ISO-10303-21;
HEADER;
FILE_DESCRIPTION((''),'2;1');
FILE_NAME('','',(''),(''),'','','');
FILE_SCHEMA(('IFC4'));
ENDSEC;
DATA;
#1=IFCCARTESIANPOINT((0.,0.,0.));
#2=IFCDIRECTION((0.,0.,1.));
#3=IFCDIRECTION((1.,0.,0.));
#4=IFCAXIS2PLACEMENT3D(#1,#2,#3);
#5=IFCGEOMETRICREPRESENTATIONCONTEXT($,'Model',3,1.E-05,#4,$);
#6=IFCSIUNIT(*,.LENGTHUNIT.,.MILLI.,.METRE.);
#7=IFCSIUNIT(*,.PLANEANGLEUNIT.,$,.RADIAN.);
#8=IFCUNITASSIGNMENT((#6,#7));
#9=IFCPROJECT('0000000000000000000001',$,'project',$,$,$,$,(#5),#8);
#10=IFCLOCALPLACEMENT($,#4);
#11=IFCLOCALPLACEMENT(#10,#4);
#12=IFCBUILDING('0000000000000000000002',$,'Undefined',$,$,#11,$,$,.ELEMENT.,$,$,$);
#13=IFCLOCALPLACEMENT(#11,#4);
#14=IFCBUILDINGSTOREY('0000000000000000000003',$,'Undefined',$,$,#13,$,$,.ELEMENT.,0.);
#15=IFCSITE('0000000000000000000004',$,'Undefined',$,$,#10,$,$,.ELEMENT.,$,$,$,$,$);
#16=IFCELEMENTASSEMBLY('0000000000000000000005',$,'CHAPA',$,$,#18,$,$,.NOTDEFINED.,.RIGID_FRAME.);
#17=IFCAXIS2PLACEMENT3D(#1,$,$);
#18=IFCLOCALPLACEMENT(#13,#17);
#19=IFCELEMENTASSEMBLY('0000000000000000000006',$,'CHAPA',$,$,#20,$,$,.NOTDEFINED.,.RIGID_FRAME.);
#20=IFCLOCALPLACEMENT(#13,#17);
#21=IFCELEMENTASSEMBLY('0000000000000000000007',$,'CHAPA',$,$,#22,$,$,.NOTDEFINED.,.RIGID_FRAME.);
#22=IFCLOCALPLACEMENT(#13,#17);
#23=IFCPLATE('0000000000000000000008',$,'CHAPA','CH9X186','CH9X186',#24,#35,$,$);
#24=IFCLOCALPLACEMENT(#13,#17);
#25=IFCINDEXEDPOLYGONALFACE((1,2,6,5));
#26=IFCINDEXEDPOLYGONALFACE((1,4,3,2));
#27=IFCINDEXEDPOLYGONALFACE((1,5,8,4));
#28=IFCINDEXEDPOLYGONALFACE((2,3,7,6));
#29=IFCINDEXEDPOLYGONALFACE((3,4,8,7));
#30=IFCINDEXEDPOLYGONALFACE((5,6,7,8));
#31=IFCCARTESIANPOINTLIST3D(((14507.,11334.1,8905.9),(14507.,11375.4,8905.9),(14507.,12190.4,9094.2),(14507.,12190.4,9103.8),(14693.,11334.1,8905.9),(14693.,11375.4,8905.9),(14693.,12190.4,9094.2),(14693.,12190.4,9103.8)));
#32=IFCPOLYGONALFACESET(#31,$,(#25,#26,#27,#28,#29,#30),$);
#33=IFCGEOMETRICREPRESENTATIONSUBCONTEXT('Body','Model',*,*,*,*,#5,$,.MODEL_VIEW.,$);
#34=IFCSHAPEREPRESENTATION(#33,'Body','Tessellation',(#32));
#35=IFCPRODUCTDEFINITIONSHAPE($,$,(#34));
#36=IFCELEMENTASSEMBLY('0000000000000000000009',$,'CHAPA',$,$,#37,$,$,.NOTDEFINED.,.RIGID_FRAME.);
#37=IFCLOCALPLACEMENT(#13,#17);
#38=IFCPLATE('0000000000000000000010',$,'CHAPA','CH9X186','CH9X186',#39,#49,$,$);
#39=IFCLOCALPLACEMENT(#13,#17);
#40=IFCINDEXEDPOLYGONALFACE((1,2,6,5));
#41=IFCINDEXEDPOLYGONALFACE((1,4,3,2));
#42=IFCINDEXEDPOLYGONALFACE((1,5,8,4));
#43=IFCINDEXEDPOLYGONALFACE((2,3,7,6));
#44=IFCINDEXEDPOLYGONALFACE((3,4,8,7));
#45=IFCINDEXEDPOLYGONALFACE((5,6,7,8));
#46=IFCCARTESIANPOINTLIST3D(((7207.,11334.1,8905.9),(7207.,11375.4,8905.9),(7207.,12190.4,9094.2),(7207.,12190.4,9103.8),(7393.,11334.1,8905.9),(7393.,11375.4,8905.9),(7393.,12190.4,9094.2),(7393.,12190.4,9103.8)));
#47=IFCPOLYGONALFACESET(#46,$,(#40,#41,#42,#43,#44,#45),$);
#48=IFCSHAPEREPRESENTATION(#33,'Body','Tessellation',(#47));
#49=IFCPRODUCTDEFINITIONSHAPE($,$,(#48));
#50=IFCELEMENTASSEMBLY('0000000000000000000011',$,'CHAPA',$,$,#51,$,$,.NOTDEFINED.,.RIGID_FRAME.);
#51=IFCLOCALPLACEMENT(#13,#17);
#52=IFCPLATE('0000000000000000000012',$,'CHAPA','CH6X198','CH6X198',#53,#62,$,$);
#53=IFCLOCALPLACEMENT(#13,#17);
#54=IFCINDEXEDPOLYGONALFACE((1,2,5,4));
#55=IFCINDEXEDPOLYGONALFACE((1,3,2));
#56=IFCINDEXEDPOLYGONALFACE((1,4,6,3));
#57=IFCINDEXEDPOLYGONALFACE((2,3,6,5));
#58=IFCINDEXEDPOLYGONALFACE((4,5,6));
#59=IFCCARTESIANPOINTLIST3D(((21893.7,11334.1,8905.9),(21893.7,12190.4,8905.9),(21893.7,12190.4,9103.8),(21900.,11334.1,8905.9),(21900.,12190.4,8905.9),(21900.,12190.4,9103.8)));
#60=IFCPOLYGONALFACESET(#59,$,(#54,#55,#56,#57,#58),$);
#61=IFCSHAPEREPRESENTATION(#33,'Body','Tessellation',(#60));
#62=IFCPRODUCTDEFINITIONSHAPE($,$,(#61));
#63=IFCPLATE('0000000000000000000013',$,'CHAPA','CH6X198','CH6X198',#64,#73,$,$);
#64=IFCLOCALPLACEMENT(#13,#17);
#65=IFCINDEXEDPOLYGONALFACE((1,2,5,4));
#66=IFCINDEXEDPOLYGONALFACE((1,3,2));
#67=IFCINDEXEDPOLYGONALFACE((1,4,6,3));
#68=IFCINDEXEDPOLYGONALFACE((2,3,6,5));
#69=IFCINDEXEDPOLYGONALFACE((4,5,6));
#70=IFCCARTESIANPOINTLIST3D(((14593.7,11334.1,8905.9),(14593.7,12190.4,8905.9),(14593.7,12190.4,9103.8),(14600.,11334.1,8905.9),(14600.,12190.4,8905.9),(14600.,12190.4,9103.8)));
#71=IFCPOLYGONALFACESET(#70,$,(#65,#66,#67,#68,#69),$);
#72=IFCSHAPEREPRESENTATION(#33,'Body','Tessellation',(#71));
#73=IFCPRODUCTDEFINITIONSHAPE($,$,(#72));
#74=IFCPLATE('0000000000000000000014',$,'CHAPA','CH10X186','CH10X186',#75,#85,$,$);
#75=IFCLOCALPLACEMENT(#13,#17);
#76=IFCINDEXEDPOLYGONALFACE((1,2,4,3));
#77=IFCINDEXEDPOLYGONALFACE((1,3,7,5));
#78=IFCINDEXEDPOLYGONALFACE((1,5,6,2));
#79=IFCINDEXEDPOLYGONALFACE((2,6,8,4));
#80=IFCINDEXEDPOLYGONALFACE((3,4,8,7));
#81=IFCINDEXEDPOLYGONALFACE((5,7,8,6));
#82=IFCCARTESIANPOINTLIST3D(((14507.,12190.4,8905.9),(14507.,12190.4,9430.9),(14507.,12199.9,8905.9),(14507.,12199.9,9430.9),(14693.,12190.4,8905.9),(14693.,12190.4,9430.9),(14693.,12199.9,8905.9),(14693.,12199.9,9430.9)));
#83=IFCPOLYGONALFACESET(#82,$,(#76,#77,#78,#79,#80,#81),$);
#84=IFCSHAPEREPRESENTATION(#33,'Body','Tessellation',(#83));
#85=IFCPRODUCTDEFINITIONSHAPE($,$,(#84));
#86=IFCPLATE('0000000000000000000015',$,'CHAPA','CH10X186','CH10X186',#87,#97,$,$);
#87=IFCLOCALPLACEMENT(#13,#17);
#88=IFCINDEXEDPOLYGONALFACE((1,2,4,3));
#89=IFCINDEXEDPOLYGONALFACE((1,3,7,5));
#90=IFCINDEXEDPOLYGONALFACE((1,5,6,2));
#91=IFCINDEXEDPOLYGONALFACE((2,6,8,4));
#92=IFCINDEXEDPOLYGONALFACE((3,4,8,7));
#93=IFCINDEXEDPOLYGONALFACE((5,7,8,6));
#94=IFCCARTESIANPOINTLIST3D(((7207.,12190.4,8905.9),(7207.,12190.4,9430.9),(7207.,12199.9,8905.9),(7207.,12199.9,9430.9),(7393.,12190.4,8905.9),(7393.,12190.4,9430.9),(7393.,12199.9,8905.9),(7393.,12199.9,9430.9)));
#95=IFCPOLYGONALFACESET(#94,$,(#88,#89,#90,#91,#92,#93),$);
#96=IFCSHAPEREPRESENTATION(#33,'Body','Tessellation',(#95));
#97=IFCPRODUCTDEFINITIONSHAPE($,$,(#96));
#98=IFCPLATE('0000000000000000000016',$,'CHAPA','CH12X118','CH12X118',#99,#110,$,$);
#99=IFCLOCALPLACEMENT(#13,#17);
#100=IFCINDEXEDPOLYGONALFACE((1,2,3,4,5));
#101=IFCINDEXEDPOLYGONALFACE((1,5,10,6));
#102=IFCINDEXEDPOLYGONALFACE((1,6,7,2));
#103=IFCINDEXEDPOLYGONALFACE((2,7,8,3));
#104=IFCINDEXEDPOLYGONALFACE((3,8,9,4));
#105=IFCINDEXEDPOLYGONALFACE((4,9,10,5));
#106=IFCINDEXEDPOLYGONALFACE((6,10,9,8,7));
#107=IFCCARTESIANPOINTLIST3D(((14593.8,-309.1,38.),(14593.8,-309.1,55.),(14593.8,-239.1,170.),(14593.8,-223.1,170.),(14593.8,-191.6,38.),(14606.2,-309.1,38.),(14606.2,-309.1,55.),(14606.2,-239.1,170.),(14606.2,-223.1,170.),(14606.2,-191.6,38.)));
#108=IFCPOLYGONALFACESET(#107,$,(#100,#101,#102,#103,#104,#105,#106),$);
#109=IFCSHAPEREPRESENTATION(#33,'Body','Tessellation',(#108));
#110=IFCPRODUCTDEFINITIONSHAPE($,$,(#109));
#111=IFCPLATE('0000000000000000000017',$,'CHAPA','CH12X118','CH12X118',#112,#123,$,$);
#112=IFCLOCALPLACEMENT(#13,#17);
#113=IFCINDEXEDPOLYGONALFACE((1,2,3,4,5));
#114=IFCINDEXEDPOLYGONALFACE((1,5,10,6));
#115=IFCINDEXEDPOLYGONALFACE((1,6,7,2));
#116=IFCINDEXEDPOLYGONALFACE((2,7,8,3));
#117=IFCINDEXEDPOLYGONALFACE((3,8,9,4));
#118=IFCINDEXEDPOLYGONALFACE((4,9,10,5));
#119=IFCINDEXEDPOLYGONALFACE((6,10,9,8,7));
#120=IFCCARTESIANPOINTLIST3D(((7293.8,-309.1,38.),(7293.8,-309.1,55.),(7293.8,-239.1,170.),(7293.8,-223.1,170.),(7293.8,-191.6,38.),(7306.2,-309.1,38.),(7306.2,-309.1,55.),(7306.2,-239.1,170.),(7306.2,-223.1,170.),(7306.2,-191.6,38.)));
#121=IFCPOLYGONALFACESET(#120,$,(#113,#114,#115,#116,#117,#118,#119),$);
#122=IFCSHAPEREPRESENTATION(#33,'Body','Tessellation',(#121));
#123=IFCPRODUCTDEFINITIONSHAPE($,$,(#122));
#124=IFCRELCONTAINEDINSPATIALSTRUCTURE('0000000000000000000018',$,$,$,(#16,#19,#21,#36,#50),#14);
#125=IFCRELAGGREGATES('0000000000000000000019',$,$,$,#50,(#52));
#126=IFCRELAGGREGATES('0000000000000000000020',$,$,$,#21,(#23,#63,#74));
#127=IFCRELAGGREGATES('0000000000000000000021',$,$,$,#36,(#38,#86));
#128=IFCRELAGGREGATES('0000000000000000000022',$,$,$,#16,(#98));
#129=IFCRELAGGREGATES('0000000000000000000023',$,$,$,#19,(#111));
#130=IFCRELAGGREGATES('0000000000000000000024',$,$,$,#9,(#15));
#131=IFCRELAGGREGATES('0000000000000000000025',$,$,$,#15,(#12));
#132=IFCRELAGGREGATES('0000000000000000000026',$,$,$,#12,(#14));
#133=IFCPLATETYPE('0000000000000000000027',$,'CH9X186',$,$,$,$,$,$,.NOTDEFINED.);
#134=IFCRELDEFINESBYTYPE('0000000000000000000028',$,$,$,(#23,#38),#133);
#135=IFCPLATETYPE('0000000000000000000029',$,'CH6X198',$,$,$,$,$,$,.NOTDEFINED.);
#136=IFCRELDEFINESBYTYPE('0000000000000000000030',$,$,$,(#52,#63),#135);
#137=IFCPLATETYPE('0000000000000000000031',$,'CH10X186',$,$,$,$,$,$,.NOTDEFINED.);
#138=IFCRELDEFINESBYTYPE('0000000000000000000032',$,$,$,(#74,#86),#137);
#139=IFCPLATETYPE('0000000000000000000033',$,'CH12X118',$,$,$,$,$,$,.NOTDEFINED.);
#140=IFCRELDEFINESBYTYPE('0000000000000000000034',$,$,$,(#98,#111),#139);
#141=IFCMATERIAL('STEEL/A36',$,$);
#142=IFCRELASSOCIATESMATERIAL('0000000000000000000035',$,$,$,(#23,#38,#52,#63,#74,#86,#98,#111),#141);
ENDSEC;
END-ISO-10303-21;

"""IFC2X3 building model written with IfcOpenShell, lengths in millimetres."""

from ifc_helpers import new_model, si_unit, frame, origin_with_axes, place, context, subcontext, project, spatial, polyline, outline, extrude, clip, halfspace, material, type_object, element, aggregate, save


model = new_model("IFC2X3")

# Units and contexts
model_context = context("Model", 3, precision=1e-05, world=origin_with_axes())
body_context = subcontext(model_context, "Body", "Model", "MODEL_VIEW")
ifc_project = project(units=[si_unit("LENGTHUNIT", "METRE", prefix="MILLI"), si_unit("PLANEANGLEUNIT", "RADIAN")], contexts=[model_context])

# Site, building, storey
site_placement = place(None, origin_with_axes())
site = spatial("IfcSite", under=ifc_project, at=site_placement, Name="Undefined", CompositionType="ELEMENT")
building_placement = place(site_placement, origin_with_axes())
building = spatial("IfcBuilding", under=site, at=building_placement, Name="Undefined", CompositionType="ELEMENT")
storey_placement = place(building_placement, origin_with_axes())
storey = spatial("IfcBuildingStorey", under=building, at=storey_placement, Name="Undefined", CompositionType="ELEMENT", Elevation=0.0)

# Element assemblies
assembly_1_placement = place(storey_placement, origin_with_axes())
assembly_1 = element("IfcElementAssembly", 1, at=assembly_1_placement, inside=storey, Name="CHAPA", AssemblyPlace="NOTDEFINED", PredefinedType="RIGID_FRAME")
assembly_2_placement = place(storey_placement, origin_with_axes())
assembly_2 = element("IfcElementAssembly", 2, at=assembly_2_placement, inside=storey, Name="CHAPA", AssemblyPlace="NOTDEFINED", PredefinedType="RIGID_FRAME")

# Shared definitions
ifc_material_1 = material(Name="STEEL/A36")

# Element assemblies, plates
assembly_3_placement = place(storey_placement, origin_with_axes())
assembly_3 = element("IfcElementAssembly", 3, at=assembly_3_placement, inside=storey, Name="CHAPA", AssemblyPlace="NOTDEFINED", PredefinedType="RIGID_FRAME")
plate_type_1 = type_object("IfcPlateType", Name="CH9X186", PredefinedType="NOTDEFINED")
plate_1_placement = place(assembly_3_placement, frame((14693.0, 12191.4, 9099.3), z_axis=(0.0, -0.225125, 0.97433), x_axis=(-1.0, 0.0, 0.0)))
plate_1 = element("IfcPlate", 4, at=plate_1_placement, type_object=plate_type_1, material=ifc_material_1, Name="CHAPA", Description="CH9X186", ObjectType="CH9X186", context=body_context, shape_type="Clipping", body=[
    clip(clip(extrude(outline(polyline([(0.0, 0.0), (186.0, 0.0), (186.0, 878.9), (0.0, 878.9), (0.0, 0.0)])), frame((0.0, 0.0, -4.7), z_axis=(0.0, 0.0, 1.0), x_axis=(1.0, 0.0, 0.0)), (0.0, 0.0, 1.0), 9.3), halfspace(frame((186.0, -500.0, -314.0), z_axis=(0.0, 0.225128, -0.974329), x_axis=(0.0, 0.974329, 0.225128)), False)), halfspace(frame((0.0, 2.1, -4.6), z_axis=(0.0, -0.97433, -0.225125), x_axis=(0.0, -0.225125, 0.97433)), False)),
])
assembly_4_placement = place(storey_placement, origin_with_axes())
assembly_4 = element("IfcElementAssembly", 5, at=assembly_4_placement, inside=storey, Name="CHAPA", AssemblyPlace="NOTDEFINED", PredefinedType="RIGID_FRAME")
plate_2_placement = place(assembly_4_placement, frame((7393.0, 12191.4, 9099.3), z_axis=(0.0, -0.225125, 0.97433), x_axis=(-1.0, 0.0, 0.0)))
plate_2 = element("IfcPlate", 6, at=plate_2_placement, type_object=plate_type_1, material=ifc_material_1, Name="CHAPA", Description="CH9X186", ObjectType="CH9X186", context=body_context, shape_type="Clipping", body=[
    clip(clip(extrude(outline(polyline([(0.0, 0.0), (186.0, 0.0), (186.0, 878.9), (0.0, 878.9), (0.0, 0.0)])), frame((0.0, 0.0, -4.7), z_axis=(0.0, 0.0, 1.0), x_axis=(1.0, 0.0, 0.0)), (0.0, 0.0, 1.0), 9.3), halfspace(frame((186.0, -500.0, -314.0), z_axis=(0.0, 0.225128, -0.974329), x_axis=(0.0, 0.974329, 0.225128)), False)), halfspace(frame((0.0, 2.1, -4.6), z_axis=(0.0, -0.97433, -0.225125), x_axis=(0.0, -0.225125, 0.97433)), False)),
])
assembly_5_placement = place(storey_placement, origin_with_axes())
assembly_5 = element("IfcElementAssembly", 7, at=assembly_5_placement, inside=storey, Name="CHAPA", AssemblyPlace="NOTDEFINED", PredefinedType="RIGID_FRAME")
plate_type_2 = type_object("IfcPlateType", Name="CH6X198", PredefinedType="NOTDEFINED")
plate_3_placement = place(assembly_5_placement, frame((21896.8, 11334.1, 8905.9), z_axis=(1.0, 0.0, 0.0), x_axis=(0.0, 1.0, 0.0)))
plate_3 = element("IfcPlate", 8, at=plate_3_placement, type_object=plate_type_2, material=ifc_material_1, Name="CHAPA", Description="CH6X198", ObjectType="CH6X198", context=body_context, shape_type="SweptSolid", body=[
    extrude(outline(polyline([(0.0, 0.0), (856.3, 0.0), (856.3, 197.9), (0.0, 0.0)])), frame((0.0, 0.0, -3.1), z_axis=(0.0, 0.0, 1.0), x_axis=(1.0, 0.0, 0.0)), (0.0, 0.0, 1.0), 6.3),
])
aggregate(assembly_5, [plate_3])

# Plates
plate_4_placement = place(assembly_3_placement, frame((14596.9, 11334.1, 8905.9), z_axis=(1.0, 0.0, 0.0), x_axis=(0.0, 1.0, 0.0)))
plate_4 = element("IfcPlate", 9, at=plate_4_placement, type_object=plate_type_2, material=ifc_material_1, Name="CHAPA", Description="CH6X198", ObjectType="CH6X198", context=body_context, shape_type="SweptSolid", body=[
    extrude(outline(polyline([(0.0, 0.0), (856.3, 0.0), (856.3, 197.9), (0.0, 0.0)])), frame((0.0, 0.0, -3.1), z_axis=(0.0, 0.0, 1.0), x_axis=(1.0, 0.0, 0.0)), (0.0, 0.0, 1.0), 6.3),
])
plate_type_3 = type_object("IfcPlateType", Name="CH10X186", PredefinedType="NOTDEFINED")
plate_5_placement = place(assembly_3_placement, frame((14693.0, 12195.2, 9430.9), z_axis=(0.0, -1.0, 0.0), x_axis=(-1.0, 0.0, 0.0)))
plate_5 = element("IfcPlate", 10, at=plate_5_placement, type_object=plate_type_3, material=ifc_material_1, Name="CHAPA", Description="CH10X186", ObjectType="CH10X186", context=body_context, shape_type="SweptSolid", body=[
    extrude(outline(polyline([(0.0, 0.0), (186.0, 0.0), (186.0, 525.0), (0.0, 525.0), (0.0, 0.0)])), frame((0.0, 0.0, -4.8), z_axis=(0.0, 0.0, 1.0), x_axis=(1.0, 0.0, 0.0)), (0.0, 0.0, 1.0), 9.5),
])
aggregate(assembly_3, [plate_1, plate_4, plate_5])
plate_6_placement = place(assembly_4_placement, frame((7393.0, 12195.2, 9430.9), z_axis=(0.0, -1.0, 0.0), x_axis=(-1.0, 0.0, 0.0)))
plate_6 = element("IfcPlate", 11, at=plate_6_placement, type_object=plate_type_3, material=ifc_material_1, Name="CHAPA", Description="CH10X186", ObjectType="CH10X186", context=body_context, shape_type="SweptSolid", body=[
    extrude(outline(polyline([(0.0, 0.0), (186.0, 0.0), (186.0, 525.0), (0.0, 525.0), (0.0, 0.0)])), frame((0.0, 0.0, -4.8), z_axis=(0.0, 0.0, 1.0), x_axis=(1.0, 0.0, 0.0)), (0.0, 0.0, 1.0), 9.5),
])
aggregate(assembly_4, [plate_2, plate_6])
plate_type_4 = type_object("IfcPlateType", Name="CH12X118", PredefinedType="NOTDEFINED")
plate_7_placement = place(assembly_1_placement, frame((14600.0, -309.1, 38.0), z_axis=(1.0, 0.0, 0.0), x_axis=(0.0, 1.0, 0.0)))
plate_7 = element("IfcPlate", 12, at=plate_7_placement, type_object=plate_type_4, material=ifc_material_1, Name="CHAPA", Description="CH12X118", ObjectType="CH12X118", context=body_context, shape_type="SweptSolid", body=[
    extrude(outline(polyline([(0.0, 0.0), (117.5, 0.0), (85.9, 132.0), (70.0, 132.0), (0.0, 17.0), (0.0, 0.0)])), frame((0.0, 0.0, -6.2), z_axis=(0.0, 0.0, 1.0), x_axis=(1.0, 0.0, 0.0)), (0.0, 0.0, 1.0), 12.5),
])
plate_8_placement = place(assembly_2_placement, frame((7300.0, -309.1, 38.0), z_axis=(1.0, 0.0, 0.0), x_axis=(0.0, 1.0, 0.0)))
plate_8 = element("IfcPlate", 13, at=plate_8_placement, type_object=plate_type_4, material=ifc_material_1, Name="CHAPA", Description="CH12X118", ObjectType="CH12X118", context=body_context, shape_type="SweptSolid", body=[
    extrude(outline(polyline([(0.0, 0.0), (117.5, 0.0), (85.9, 132.0), (70.0, 132.0), (0.0, 17.0), (0.0, 0.0)])), frame((0.0, 0.0, -6.2), z_axis=(0.0, 0.0, 1.0), x_axis=(1.0, 0.0, 0.0)), (0.0, 0.0, 1.0), 12.5),
])

aggregate(assembly_1, [plate_7])
aggregate(assembly_2, [plate_8])

save(model, "model.ifc")
